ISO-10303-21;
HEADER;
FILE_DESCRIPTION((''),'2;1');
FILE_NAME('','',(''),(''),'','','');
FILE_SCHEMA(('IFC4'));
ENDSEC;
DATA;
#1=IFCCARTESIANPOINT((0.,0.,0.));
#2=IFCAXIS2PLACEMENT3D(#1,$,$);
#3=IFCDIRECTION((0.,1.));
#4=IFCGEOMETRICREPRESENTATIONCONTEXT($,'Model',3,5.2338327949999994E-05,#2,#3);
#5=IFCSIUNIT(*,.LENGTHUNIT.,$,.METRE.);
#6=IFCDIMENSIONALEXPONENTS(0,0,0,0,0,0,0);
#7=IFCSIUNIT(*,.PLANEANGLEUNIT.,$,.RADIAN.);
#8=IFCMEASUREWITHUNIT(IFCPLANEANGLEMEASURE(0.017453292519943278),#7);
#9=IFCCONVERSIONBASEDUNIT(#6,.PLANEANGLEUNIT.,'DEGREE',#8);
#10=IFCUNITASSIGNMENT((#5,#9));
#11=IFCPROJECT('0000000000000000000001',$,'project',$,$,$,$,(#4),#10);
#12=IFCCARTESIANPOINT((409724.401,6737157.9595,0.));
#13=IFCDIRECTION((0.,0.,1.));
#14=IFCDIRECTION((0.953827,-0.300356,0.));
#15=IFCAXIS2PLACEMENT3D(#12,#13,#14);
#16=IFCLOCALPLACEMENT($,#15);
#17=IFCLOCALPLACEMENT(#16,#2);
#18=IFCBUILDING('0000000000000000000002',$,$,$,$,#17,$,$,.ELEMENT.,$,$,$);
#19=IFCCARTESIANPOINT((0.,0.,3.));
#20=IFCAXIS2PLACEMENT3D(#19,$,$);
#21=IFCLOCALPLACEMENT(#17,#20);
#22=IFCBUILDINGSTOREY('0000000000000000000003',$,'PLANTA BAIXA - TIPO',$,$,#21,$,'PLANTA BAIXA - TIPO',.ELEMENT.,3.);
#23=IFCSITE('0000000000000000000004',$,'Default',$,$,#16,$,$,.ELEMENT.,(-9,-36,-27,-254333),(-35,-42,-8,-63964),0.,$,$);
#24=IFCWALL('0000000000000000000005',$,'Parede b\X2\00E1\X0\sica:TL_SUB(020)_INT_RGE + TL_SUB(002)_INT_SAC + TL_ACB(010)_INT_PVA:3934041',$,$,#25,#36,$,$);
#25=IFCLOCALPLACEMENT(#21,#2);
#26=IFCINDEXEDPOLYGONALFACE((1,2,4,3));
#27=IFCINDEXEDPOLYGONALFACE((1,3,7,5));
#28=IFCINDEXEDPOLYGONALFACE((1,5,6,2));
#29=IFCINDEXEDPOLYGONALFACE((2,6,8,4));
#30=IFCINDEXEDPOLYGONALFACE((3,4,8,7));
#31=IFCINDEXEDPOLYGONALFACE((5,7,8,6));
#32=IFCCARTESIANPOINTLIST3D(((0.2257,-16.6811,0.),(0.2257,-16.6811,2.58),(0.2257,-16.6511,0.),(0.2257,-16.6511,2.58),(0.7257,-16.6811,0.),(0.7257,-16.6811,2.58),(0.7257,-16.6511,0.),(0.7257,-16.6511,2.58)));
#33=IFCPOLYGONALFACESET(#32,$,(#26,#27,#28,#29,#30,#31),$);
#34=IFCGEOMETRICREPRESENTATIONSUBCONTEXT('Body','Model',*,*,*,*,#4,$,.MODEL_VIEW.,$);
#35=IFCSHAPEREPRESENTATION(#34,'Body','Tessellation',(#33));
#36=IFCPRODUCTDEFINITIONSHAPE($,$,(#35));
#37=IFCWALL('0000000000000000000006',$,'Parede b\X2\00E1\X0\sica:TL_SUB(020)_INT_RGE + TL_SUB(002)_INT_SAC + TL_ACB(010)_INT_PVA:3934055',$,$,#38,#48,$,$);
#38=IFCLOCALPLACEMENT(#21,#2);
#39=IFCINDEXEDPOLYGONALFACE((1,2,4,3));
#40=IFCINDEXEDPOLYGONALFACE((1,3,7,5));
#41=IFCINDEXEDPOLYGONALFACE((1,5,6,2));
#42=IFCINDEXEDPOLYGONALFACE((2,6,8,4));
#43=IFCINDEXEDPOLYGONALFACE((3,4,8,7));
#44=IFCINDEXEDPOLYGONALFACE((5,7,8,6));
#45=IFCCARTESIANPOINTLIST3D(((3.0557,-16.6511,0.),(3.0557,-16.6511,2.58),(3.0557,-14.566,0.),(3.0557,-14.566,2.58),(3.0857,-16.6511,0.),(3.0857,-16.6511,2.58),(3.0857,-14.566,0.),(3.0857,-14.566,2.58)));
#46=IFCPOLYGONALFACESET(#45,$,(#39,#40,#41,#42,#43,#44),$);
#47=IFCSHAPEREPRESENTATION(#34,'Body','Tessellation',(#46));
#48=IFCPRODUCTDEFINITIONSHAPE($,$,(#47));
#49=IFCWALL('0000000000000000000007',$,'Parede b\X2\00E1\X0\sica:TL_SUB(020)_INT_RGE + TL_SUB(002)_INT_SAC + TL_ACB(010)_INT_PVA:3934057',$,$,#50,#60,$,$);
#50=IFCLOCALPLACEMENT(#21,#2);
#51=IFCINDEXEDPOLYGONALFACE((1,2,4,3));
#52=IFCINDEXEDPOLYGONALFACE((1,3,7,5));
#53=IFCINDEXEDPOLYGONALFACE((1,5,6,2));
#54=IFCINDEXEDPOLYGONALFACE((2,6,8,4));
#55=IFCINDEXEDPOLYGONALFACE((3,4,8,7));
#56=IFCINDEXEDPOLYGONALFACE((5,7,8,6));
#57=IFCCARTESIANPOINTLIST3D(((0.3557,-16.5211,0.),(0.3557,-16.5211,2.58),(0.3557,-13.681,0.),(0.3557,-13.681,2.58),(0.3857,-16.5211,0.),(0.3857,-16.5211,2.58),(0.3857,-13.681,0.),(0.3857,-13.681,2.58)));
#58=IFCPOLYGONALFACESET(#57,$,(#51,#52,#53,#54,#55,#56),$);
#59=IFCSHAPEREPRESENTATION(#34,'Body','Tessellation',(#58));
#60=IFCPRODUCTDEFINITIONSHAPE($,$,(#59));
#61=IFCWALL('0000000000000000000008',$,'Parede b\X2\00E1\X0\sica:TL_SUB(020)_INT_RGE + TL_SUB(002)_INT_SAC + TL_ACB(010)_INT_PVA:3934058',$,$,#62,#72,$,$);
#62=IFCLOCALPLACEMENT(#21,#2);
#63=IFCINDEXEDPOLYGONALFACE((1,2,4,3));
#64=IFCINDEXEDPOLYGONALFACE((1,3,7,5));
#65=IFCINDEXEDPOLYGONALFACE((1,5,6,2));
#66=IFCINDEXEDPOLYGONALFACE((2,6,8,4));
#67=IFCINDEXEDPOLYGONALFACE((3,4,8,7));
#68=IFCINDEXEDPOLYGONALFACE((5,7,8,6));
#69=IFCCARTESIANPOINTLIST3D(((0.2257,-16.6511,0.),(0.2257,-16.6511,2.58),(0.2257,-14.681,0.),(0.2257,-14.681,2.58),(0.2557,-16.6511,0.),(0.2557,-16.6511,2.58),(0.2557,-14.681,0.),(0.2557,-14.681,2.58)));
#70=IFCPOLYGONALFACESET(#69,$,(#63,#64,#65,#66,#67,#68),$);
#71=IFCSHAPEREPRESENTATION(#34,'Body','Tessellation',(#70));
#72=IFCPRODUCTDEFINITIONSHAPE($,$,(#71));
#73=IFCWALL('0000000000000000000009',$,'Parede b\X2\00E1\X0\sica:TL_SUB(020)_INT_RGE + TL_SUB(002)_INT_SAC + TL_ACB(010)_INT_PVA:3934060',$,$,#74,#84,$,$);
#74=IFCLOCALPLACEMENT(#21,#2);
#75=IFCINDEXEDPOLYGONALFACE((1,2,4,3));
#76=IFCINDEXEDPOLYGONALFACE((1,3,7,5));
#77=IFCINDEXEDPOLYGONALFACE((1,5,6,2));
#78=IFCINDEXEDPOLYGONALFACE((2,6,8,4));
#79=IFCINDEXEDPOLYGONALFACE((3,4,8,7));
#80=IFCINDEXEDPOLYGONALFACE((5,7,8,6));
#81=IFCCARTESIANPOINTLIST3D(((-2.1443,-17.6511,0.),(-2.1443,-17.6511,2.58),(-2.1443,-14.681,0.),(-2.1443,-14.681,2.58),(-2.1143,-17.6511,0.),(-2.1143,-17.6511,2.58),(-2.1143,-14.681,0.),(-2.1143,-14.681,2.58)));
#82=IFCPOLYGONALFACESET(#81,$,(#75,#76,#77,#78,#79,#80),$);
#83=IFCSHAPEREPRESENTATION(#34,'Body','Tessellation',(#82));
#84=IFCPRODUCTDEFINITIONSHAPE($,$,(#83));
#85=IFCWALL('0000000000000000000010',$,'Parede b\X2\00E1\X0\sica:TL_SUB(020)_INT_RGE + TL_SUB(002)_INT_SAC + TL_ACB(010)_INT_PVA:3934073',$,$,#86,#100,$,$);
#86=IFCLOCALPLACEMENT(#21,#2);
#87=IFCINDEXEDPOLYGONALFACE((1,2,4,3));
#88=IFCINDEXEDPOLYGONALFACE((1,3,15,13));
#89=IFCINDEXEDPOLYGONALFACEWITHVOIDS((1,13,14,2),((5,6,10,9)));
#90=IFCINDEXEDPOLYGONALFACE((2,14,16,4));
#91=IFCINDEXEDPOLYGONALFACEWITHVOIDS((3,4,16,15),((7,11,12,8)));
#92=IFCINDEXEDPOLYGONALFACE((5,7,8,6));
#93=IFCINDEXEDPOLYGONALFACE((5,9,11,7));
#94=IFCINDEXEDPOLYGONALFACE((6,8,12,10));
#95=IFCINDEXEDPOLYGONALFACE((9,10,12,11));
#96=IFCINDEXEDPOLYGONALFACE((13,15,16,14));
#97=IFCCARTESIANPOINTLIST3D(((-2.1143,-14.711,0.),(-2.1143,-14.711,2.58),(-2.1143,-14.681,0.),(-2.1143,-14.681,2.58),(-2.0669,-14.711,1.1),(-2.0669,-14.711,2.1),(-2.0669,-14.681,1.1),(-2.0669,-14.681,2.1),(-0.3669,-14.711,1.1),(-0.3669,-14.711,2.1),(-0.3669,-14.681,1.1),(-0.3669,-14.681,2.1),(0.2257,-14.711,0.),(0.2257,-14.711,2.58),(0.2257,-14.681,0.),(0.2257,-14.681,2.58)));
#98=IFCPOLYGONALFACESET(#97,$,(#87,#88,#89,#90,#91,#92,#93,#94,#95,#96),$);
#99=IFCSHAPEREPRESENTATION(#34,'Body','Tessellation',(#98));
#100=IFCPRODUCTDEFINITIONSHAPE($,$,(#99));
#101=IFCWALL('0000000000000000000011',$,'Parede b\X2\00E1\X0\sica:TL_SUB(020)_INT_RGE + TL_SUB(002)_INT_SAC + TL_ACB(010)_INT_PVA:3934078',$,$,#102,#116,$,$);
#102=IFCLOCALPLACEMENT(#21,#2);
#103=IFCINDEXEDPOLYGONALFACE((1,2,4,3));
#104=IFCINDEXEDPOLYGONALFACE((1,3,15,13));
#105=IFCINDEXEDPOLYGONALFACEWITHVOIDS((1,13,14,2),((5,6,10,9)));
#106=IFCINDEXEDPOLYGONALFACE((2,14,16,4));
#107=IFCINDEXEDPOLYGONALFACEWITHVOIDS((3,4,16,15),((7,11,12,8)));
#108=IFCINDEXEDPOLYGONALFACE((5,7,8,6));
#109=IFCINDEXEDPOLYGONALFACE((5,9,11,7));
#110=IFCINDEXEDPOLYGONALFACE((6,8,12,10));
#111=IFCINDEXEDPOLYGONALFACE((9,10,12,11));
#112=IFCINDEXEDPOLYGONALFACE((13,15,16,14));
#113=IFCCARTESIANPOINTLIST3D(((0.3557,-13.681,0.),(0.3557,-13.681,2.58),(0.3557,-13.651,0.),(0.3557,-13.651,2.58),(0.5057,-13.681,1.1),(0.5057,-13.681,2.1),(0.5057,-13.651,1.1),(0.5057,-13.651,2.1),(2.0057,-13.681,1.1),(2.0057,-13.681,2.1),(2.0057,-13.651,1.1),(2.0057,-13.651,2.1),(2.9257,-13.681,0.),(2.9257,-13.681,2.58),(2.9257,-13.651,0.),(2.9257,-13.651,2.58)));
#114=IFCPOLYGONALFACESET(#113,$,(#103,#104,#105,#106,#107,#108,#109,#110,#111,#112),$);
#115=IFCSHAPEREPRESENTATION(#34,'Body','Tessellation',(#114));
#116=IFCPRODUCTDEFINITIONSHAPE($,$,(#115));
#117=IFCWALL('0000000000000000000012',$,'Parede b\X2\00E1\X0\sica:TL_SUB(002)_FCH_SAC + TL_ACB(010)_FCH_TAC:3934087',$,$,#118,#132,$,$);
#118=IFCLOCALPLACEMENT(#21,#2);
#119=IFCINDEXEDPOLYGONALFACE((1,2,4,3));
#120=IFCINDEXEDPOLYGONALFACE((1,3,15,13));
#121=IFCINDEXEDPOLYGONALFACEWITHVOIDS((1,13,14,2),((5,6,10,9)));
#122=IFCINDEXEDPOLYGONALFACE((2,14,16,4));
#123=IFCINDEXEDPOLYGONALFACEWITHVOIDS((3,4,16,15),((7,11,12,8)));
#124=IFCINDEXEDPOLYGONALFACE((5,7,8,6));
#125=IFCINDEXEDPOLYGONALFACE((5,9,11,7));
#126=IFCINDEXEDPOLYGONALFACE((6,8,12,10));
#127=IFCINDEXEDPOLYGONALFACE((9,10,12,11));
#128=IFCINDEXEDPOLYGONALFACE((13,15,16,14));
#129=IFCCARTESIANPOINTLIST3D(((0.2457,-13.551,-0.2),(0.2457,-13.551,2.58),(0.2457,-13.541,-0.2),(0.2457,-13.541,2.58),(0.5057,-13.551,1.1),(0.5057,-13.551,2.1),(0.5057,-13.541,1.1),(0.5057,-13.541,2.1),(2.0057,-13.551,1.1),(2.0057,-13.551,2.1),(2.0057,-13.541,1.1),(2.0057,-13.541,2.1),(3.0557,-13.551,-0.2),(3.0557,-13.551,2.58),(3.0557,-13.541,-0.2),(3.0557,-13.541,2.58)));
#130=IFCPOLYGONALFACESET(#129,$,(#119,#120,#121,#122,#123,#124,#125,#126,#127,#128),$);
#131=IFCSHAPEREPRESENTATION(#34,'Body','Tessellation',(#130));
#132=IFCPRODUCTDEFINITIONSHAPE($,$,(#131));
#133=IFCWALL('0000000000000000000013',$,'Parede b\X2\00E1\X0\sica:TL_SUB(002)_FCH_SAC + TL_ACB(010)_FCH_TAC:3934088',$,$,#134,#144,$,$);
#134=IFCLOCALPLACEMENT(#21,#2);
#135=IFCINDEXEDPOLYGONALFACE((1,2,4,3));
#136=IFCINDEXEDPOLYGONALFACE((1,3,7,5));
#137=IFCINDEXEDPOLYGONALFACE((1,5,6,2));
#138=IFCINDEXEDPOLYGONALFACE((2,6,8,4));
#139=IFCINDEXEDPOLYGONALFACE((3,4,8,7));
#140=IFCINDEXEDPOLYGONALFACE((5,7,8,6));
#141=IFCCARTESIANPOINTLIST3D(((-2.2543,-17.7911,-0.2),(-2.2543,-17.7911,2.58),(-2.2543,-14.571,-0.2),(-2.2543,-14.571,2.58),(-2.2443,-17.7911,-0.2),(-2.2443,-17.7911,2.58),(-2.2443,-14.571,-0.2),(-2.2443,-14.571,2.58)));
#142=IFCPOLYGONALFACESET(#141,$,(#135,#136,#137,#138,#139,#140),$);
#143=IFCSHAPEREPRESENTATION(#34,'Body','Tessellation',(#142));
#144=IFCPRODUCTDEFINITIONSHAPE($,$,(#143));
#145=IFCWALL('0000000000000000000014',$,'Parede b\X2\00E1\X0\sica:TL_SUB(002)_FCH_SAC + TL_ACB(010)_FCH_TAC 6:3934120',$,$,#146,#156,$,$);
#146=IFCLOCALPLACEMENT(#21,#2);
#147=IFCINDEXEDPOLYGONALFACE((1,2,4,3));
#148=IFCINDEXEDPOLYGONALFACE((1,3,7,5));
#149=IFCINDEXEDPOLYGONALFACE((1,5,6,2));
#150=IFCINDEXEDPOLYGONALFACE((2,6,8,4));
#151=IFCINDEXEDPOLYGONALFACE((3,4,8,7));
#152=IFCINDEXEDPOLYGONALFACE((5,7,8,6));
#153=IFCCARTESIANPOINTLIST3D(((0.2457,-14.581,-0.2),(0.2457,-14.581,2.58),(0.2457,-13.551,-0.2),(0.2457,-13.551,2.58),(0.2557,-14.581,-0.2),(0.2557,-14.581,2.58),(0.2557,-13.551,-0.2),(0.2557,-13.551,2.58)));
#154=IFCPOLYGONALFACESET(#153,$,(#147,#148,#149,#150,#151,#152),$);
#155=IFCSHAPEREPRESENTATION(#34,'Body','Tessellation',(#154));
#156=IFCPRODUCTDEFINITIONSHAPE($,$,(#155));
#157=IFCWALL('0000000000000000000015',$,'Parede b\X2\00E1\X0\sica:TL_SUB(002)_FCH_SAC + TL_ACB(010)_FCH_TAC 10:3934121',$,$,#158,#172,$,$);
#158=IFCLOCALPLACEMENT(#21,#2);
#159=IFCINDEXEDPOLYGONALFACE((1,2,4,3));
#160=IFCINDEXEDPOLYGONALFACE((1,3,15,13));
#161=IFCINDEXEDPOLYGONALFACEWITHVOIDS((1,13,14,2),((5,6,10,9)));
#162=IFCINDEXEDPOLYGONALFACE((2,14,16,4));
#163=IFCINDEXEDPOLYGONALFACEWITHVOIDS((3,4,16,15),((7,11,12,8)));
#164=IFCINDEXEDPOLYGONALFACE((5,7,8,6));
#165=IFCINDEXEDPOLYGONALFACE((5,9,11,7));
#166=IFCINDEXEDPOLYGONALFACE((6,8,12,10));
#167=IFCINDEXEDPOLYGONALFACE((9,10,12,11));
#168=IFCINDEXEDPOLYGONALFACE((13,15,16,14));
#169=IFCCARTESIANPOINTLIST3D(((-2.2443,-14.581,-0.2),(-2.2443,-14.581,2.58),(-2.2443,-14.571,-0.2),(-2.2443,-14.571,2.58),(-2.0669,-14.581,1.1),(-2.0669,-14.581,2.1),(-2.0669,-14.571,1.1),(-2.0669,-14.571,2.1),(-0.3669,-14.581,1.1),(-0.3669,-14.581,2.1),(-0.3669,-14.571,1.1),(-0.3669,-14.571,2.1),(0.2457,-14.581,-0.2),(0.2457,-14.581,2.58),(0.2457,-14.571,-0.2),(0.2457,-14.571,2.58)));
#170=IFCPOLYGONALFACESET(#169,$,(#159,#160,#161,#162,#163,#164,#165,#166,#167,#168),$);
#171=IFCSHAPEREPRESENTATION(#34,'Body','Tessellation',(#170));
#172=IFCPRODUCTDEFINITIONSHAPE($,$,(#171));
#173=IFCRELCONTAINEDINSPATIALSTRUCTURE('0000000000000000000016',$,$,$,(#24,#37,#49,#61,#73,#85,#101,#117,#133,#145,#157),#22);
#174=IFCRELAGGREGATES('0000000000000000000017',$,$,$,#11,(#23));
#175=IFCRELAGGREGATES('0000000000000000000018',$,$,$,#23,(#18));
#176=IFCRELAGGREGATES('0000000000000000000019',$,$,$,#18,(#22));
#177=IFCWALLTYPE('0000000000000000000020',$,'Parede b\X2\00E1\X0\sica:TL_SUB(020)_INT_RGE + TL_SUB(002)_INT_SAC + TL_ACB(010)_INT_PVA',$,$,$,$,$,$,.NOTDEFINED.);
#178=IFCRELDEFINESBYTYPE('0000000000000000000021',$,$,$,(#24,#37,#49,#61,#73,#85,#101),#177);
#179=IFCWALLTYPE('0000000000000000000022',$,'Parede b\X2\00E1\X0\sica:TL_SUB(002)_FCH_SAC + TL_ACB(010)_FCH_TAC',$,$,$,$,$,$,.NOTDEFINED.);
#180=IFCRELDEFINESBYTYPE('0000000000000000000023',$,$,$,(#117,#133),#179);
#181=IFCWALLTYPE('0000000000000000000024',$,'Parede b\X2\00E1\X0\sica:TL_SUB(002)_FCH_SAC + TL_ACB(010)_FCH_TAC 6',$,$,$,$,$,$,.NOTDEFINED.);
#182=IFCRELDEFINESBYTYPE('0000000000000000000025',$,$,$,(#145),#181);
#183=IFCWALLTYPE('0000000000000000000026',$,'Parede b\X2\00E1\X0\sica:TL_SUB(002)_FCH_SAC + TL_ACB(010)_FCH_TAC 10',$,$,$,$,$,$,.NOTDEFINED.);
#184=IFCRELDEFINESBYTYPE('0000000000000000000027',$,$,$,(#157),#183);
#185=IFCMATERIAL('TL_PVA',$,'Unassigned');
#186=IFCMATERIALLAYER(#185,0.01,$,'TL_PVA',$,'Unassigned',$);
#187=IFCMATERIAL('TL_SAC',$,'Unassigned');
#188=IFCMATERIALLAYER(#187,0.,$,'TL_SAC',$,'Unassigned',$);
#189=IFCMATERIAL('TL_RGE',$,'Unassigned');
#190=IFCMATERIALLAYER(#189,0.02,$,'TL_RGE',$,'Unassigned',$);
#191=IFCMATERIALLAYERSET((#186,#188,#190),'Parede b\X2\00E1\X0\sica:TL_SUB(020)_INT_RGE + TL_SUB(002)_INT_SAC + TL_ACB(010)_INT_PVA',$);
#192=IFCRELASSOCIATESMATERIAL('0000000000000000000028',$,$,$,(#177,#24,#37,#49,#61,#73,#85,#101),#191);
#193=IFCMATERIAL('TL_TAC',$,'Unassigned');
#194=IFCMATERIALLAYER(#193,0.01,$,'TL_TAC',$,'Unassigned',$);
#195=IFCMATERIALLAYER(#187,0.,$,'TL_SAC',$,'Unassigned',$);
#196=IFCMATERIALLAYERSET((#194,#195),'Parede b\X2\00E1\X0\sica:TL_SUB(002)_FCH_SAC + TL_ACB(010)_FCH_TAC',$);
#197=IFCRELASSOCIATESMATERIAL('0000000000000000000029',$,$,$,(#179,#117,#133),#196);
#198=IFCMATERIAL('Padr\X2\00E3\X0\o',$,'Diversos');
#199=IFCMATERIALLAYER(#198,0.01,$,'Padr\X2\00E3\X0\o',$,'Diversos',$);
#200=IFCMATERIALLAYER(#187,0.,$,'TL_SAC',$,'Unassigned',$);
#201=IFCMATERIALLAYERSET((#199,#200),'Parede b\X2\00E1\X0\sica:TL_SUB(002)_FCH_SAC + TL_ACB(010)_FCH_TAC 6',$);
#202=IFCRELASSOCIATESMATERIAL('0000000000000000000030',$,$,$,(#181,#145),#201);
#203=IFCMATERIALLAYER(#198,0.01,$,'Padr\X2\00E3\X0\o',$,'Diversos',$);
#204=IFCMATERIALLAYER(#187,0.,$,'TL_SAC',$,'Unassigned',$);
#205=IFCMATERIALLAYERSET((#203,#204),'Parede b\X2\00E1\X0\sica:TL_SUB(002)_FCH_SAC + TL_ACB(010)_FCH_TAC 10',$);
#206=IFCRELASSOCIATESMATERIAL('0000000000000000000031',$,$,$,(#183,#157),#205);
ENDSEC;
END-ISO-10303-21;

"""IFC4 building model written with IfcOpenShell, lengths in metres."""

from ifc_helpers import new_model, entity, si_unit, converted_unit, direction, frame, frame_2d, origin, place, context, subcontext, project, spatial, rectangle, extrude, material, layer, layer_set, layer_usage, type_object, element, save


model = new_model("IFC4")

# Units and contexts
model_context = context("Model", 3, precision=5.2338327949999994e-05, world=origin(), true_north=direction((0.0, 1.0)))
body_context = subcontext(model_context, "Body", "Model", "MODEL_VIEW")
ifc_project = project(units=[si_unit("LENGTHUNIT", "METRE"), converted_unit("PLANEANGLEUNIT", "DEGREE", entity("IfcPlaneAngleMeasure", 0.017453292519943278), si_unit("PLANEANGLEUNIT", "RADIAN"), dimensions=[0, 0, 0, 0, 0, 0, 0])], contexts=[model_context])

# Site, building, storey
site_placement = place(None, frame((409724.401, 6737157.9595, 0.0), z_axis=(0.0, 0.0, 1.0), x_axis=(0.953827, -0.300356, 0.0)))
site = spatial("IfcSite", under=ifc_project, at=site_placement, Name="Default", CompositionType="ELEMENT", RefLatitude=(-9, -36, -27, -254333), RefLongitude=(-35, -42, -8, -63964), RefElevation=0.0)
building_placement = place(site_placement, origin())
building = spatial("IfcBuilding", under=site, at=building_placement, CompositionType="ELEMENT")
storey_placement = place(building_placement, frame((0.0, 0.0, 3.0)))
storey = spatial("IfcBuildingStorey", under=building, at=storey_placement, Name="PLANTA BAIXA - TIPO", LongName="PLANTA BAIXA - TIPO", CompositionType="ELEMENT", Elevation=3.0)

# Walls
ifc_material_1 = material(Name="TL_PVA", Category="Unassigned")
ifc_layer_1 = layer(ifc_material_1, 0.01, Name="TL_PVA", Category="Unassigned")
ifc_material_2 = material(Name="TL_SAC", Category="Unassigned")
ifc_layer_2 = layer(ifc_material_2, 0.0, Name="TL_SAC", Category="Unassigned")
ifc_material_3 = material(Name="TL_RGE", Category="Unassigned")
ifc_layer_3 = layer(ifc_material_3, 0.02, Name="TL_RGE", Category="Unassigned")
ifc_layer_set_1 = layer_set([ifc_layer_1, ifc_layer_2, ifc_layer_3], Name="Parede básica:TL_SUB(020)_INT_RGE + TL_SUB(002)_INT_SAC + TL_ACB(010)_INT_PVA")
ifc_layer_usage_1 = layer_usage(ifc_layer_set_1, "AXIS2", "POSITIVE", -0.015)
wall_type_1 = type_object("IfcWallType", Name="Parede básica:TL_SUB(020)_INT_RGE + TL_SUB(002)_INT_SAC + TL_ACB(010)_INT_PVA", PredefinedType="NOTDEFINED", material=ifc_layer_set_1)
wall_1_placement = place(storey_placement, frame((0.2257, -16.6661, 0.0)))
element("IfcWall", 1, at=wall_1_placement, inside=storey, type_object=wall_type_1, material=ifc_layer_usage_1, Name="Parede básica:TL_SUB(020)_INT_RGE + TL_SUB(002)_INT_SAC + TL_ACB(010)_INT_PVA:3934041", context=body_context, shape_type="SweptSolid", body=[
    extrude(rectangle(XDim=0.5, YDim=0.03, at=frame_2d((0.25, 0.0), x_axis=(-1.0, 0.0))), origin(), (0.0, 0.0, 1.0), 2.58),
])
ifc_layer_usage_2 = layer_usage(ifc_layer_set_1, "AXIS2", "NEGATIVE", 0.015)
wall_2_placement = place(storey_placement, frame((3.0707, -14.566, 0.0), z_axis=(0.0, 0.0, 1.0), x_axis=(0.0, -1.0, 0.0)))
element("IfcWall", 2, at=wall_2_placement, inside=storey, type_object=wall_type_1, material=ifc_layer_usage_2, Name="Parede básica:TL_SUB(020)_INT_RGE + TL_SUB(002)_INT_SAC + TL_ACB(010)_INT_PVA:3934055", context=body_context, shape_type="SweptSolid", body=[
    extrude(rectangle(XDim=2.0851, YDim=0.03, at=frame_2d((1.0426, 0.0), x_axis=(-1.0, 0.0))), origin(), (0.0, 0.0, 1.0), 2.58),
])
ifc_layer_usage_3 = layer_usage(ifc_layer_set_1, "AXIS2", "NEGATIVE", 0.015)
wall_3_placement = place(storey_placement, frame((0.3707, -13.681, 0.0), z_axis=(0.0, 0.0, 1.0), x_axis=(0.0, -1.0, 0.0)))
element("IfcWall", 3, at=wall_3_placement, inside=storey, type_object=wall_type_1, material=ifc_layer_usage_3, Name="Parede básica:TL_SUB(020)_INT_RGE + TL_SUB(002)_INT_SAC + TL_ACB(010)_INT_PVA:3934057", context=body_context, shape_type="SweptSolid", body=[
    extrude(rectangle(XDim=2.8401, YDim=0.03, at=frame_2d((1.4201, 0.0), x_axis=(-1.0, 0.0))), origin(), (0.0, 0.0, 1.0), 2.58),
])
ifc_layer_usage_4 = layer_usage(ifc_layer_set_1, "AXIS2", "NEGATIVE", 0.015)
wall_4_placement = place(storey_placement, frame((0.2407, -16.6511, 0.0), z_axis=(0.0, 0.0, 1.0), x_axis=(0.0, 1.0, 0.0)))
element("IfcWall", 4, at=wall_4_placement, inside=storey, type_object=wall_type_1, material=ifc_layer_usage_4, Name="Parede básica:TL_SUB(020)_INT_RGE + TL_SUB(002)_INT_SAC + TL_ACB(010)_INT_PVA:3934058", context=body_context, shape_type="SweptSolid", body=[
    extrude(rectangle(XDim=1.9701, YDim=0.03, at=frame_2d((0.9851, 0.0), x_axis=(-1.0, 0.0))), origin(), (0.0, 0.0, 1.0), 2.58),
])
ifc_layer_usage_5 = layer_usage(ifc_layer_set_1, "AXIS2", "NEGATIVE", 0.015)
wall_5_placement = place(storey_placement, frame((-2.1293, -14.681, 0.0), z_axis=(0.0, 0.0, 1.0), x_axis=(0.0, -1.0, 0.0)))
element("IfcWall", 5, at=wall_5_placement, inside=storey, type_object=wall_type_1, material=ifc_layer_usage_5, Name="Parede básica:TL_SUB(020)_INT_RGE + TL_SUB(002)_INT_SAC + TL_ACB(010)_INT_PVA:3934060", context=body_context, shape_type="SweptSolid", body=[
    extrude(rectangle(XDim=2.9701, YDim=0.03, at=frame_2d((1.4851, 0.0), x_axis=(-1.0, 0.0))), origin(), (0.0, 0.0, 1.0), 2.58),
])

# Walls, openings
ifc_layer_usage_6 = layer_usage(ifc_layer_set_1, "AXIS2", "NEGATIVE", 0.015)
wall_6_placement = place(storey_placement, frame((0.2257, -14.696, 0.0), z_axis=(0.0, 0.0, 1.0), x_axis=(-1.0, 0.0, 0.0)))
wall_6 = element("IfcWall", 6, at=wall_6_placement, inside=storey, type_object=wall_type_1, material=ifc_layer_usage_6, Name="Parede básica:TL_SUB(020)_INT_RGE + TL_SUB(002)_INT_SAC + TL_ACB(010)_INT_PVA:3934073", context=body_context, shape_type="SweptSolid", body=[
    extrude(rectangle(XDim=2.34, YDim=0.03, at=frame_2d((1.17, 0.0), x_axis=(-1.0, 0.0))), origin(), (0.0, 0.0, 1.0), 2.58),
])
opening_1_placement = place(wall_6_placement, frame((0.2257, -14.696, 1.1)))
element("IfcOpeningElement", 7, at=opening_1_placement, cuts=wall_6, PredefinedType="OPENING", context=body_context, shape_type="SweptSolid", body=[
    extrude(rectangle(XDim=1.0, YDim=1.7, at=frame_2d((0.0, 0.0), x_axis=(0.0, 1.0))), frame((1.2169, 13.157, 0.5), z_axis=(0.0, 1.0, 0.0), x_axis=(1.0, 0.0, 0.0)), (0.0, 0.0, 1.0), 3.048),
])
ifc_layer_usage_7 = layer_usage(ifc_layer_set_1, "AXIS2", "NEGATIVE", 0.015)
wall_7_placement = place(storey_placement, frame((2.9257, -13.666, 0.0), z_axis=(0.0, 0.0, 1.0), x_axis=(-1.0, 0.0, 0.0)))
wall_7 = element("IfcWall", 8, at=wall_7_placement, inside=storey, type_object=wall_type_1, material=ifc_layer_usage_7, Name="Parede básica:TL_SUB(020)_INT_RGE + TL_SUB(002)_INT_SAC + TL_ACB(010)_INT_PVA:3934078", context=body_context, shape_type="SweptSolid", body=[
    extrude(rectangle(XDim=2.57, YDim=0.03, at=frame_2d((1.285, 0.0), x_axis=(-1.0, 0.0))), origin(), (0.0, 0.0, 1.0), 2.58),
])
opening_2_placement = place(wall_7_placement, frame((2.9257, -13.666, 1.1)))
element("IfcOpeningElement", 9, at=opening_2_placement, cuts=wall_7, PredefinedType="OPENING", context=body_context, shape_type="SweptSolid", body=[
    extrude(rectangle(XDim=1.0, YDim=1.5, at=frame_2d((0.0, 0.0), x_axis=(0.0, 1.0))), frame((-1.2557, 12.127, 0.5), z_axis=(0.0, 1.0, 0.0), x_axis=(1.0, 0.0, 0.0)), (0.0, 0.0, 1.0), 3.048),
])
ifc_material_4 = material(Name="TL_TAC", Category="Unassigned")
ifc_layer_4 = layer(ifc_material_4, 0.01, Name="TL_TAC", Category="Unassigned")
ifc_layer_5 = layer(ifc_material_2, 0.0, Name="TL_SAC", Category="Unassigned")
ifc_layer_set_2 = layer_set([ifc_layer_4, ifc_layer_5], Name="Parede básica:TL_SUB(002)_FCH_SAC + TL_ACB(010)_FCH_TAC")
ifc_layer_usage_8 = layer_usage(ifc_layer_set_2, "AXIS2", "POSITIVE", -0.005)
wall_type_2 = type_object("IfcWallType", Name="Parede básica:TL_SUB(002)_FCH_SAC + TL_ACB(010)_FCH_TAC", PredefinedType="NOTDEFINED", material=ifc_layer_set_2)
wall_8_placement = place(storey_placement, frame((3.0557, -13.546, -0.2), z_axis=(0.0, 0.0, 1.0), x_axis=(-1.0, 0.0, 0.0)))
wall_8 = element("IfcWall", 10, at=wall_8_placement, inside=storey, type_object=wall_type_2, material=ifc_layer_usage_8, Name="Parede básica:TL_SUB(002)_FCH_SAC + TL_ACB(010)_FCH_TAC:3934087", context=body_context, shape_type="SweptSolid", body=[
    extrude(rectangle(XDim=2.81, YDim=0.01, at=frame_2d((1.405, 0.0), x_axis=(-1.0, 0.0))), origin(), (0.0, 0.0, 1.0), 2.78),
])
opening_3_placement = place(wall_8_placement, frame((3.0557, -13.546, 1.3)))
element("IfcOpeningElement", 11, at=opening_3_placement, cuts=wall_8, PredefinedType="OPENING", context=body_context, shape_type="SweptSolid", body=[
    extrude(rectangle(XDim=1.0, YDim=1.5, at=frame_2d((0.0, 0.0), x_axis=(0.0, 1.0))), frame((-1.2557, 12.127, 0.5), z_axis=(0.0, 1.0, 0.0), x_axis=(1.0, 0.0, 0.0)), (0.0, 0.0, 1.0), 3.048),
])

# Walls
ifc_layer_usage_9 = layer_usage(ifc_layer_set_2, "AXIS2", "NEGATIVE", 0.005)
wall_9_placement = place(storey_placement, frame((-2.2493, -14.571, -0.2), z_axis=(0.0, 0.0, 1.0), x_axis=(0.0, -1.0, 0.0)))
element("IfcWall", 12, at=wall_9_placement, inside=storey, type_object=wall_type_2, material=ifc_layer_usage_9, Name="Parede básica:TL_SUB(002)_FCH_SAC + TL_ACB(010)_FCH_TAC:3934088", context=body_context, shape_type="SweptSolid", body=[
    extrude(rectangle(XDim=3.2201, YDim=0.01, at=frame_2d((1.6101, 0.0), x_axis=(-1.0, 0.0))), origin(), (0.0, 0.0, 1.0), 2.78),
])
ifc_material_5 = material(Name="Padrão", Category="Diversos")
ifc_layer_6 = layer(ifc_material_5, 0.01, Name="Padrão", Category="Diversos")
ifc_layer_7 = layer(ifc_material_2, 0.0, Name="TL_SAC", Category="Unassigned")
ifc_layer_set_3 = layer_set([ifc_layer_6, ifc_layer_7], Name="Parede básica:TL_SUB(002)_FCH_SAC + TL_ACB(010)_FCH_TAC 6")
ifc_layer_usage_10 = layer_usage(ifc_layer_set_3, "AXIS2", "NEGATIVE", 0.005)
wall_type_3 = type_object("IfcWallType", Name="Parede básica:TL_SUB(002)_FCH_SAC + TL_ACB(010)_FCH_TAC 6", PredefinedType="NOTDEFINED", material=ifc_layer_set_3)
wall_10_placement = place(storey_placement, frame((0.2507, -13.551, -0.2), z_axis=(0.0, 0.0, 1.0), x_axis=(0.0, -1.0, 0.0)))
element("IfcWall", 13, at=wall_10_placement, inside=storey, type_object=wall_type_3, material=ifc_layer_usage_10, Name="Parede básica:TL_SUB(002)_FCH_SAC + TL_ACB(010)_FCH_TAC 6:3934120", context=body_context, shape_type="SweptSolid", body=[
    extrude(rectangle(XDim=1.03, YDim=0.01, at=frame_2d((0.515, 0.0), x_axis=(-1.0, 0.0))), origin(), (0.0, 0.0, 1.0), 2.78),
])

# Wall, opening
ifc_layer_8 = layer(ifc_material_5, 0.01, Name="Padrão", Category="Diversos")
ifc_layer_9 = layer(ifc_material_2, 0.0, Name="TL_SAC", Category="Unassigned")
ifc_layer_set_4 = layer_set([ifc_layer_8, ifc_layer_9], Name="Parede básica:TL_SUB(002)_FCH_SAC + TL_ACB(010)_FCH_TAC 10")
ifc_layer_usage_11 = layer_usage(ifc_layer_set_4, "AXIS2", "NEGATIVE", 0.005)
wall_type_4 = type_object("IfcWallType", Name="Parede básica:TL_SUB(002)_FCH_SAC + TL_ACB(010)_FCH_TAC 10", PredefinedType="NOTDEFINED", material=ifc_layer_set_4)
wall_11_placement = place(storey_placement, frame((0.2457, -14.576, -0.2), z_axis=(0.0, 0.0, 1.0), x_axis=(-1.0, 0.0, 0.0)))
wall_11 = element("IfcWall", 14, at=wall_11_placement, inside=storey, type_object=wall_type_4, material=ifc_layer_usage_11, Name="Parede básica:TL_SUB(002)_FCH_SAC + TL_ACB(010)_FCH_TAC 10:3934121", context=body_context, shape_type="SweptSolid", body=[
    extrude(rectangle(XDim=2.49, YDim=0.01, at=frame_2d((1.245, 0.0), x_axis=(-1.0, 0.0))), origin(), (0.0, 0.0, 1.0), 2.78),
])
opening_4_placement = place(wall_11_placement, frame((0.2457, -14.576, 1.3)))
element("IfcOpeningElement", 15, at=opening_4_placement, cuts=wall_11, PredefinedType="OPENING", context=body_context, shape_type="SweptSolid", body=[
    extrude(rectangle(XDim=1.0, YDim=1.7, at=frame_2d((0.0, 0.0), x_axis=(0.0, 1.0))), frame((1.2169, 13.157, 0.5), z_axis=(0.0, 1.0, 0.0), x_axis=(1.0, 0.0, 0.0)), (0.0, 0.0, 1.0), 3.048),
])

save(model, "model.ifc")
